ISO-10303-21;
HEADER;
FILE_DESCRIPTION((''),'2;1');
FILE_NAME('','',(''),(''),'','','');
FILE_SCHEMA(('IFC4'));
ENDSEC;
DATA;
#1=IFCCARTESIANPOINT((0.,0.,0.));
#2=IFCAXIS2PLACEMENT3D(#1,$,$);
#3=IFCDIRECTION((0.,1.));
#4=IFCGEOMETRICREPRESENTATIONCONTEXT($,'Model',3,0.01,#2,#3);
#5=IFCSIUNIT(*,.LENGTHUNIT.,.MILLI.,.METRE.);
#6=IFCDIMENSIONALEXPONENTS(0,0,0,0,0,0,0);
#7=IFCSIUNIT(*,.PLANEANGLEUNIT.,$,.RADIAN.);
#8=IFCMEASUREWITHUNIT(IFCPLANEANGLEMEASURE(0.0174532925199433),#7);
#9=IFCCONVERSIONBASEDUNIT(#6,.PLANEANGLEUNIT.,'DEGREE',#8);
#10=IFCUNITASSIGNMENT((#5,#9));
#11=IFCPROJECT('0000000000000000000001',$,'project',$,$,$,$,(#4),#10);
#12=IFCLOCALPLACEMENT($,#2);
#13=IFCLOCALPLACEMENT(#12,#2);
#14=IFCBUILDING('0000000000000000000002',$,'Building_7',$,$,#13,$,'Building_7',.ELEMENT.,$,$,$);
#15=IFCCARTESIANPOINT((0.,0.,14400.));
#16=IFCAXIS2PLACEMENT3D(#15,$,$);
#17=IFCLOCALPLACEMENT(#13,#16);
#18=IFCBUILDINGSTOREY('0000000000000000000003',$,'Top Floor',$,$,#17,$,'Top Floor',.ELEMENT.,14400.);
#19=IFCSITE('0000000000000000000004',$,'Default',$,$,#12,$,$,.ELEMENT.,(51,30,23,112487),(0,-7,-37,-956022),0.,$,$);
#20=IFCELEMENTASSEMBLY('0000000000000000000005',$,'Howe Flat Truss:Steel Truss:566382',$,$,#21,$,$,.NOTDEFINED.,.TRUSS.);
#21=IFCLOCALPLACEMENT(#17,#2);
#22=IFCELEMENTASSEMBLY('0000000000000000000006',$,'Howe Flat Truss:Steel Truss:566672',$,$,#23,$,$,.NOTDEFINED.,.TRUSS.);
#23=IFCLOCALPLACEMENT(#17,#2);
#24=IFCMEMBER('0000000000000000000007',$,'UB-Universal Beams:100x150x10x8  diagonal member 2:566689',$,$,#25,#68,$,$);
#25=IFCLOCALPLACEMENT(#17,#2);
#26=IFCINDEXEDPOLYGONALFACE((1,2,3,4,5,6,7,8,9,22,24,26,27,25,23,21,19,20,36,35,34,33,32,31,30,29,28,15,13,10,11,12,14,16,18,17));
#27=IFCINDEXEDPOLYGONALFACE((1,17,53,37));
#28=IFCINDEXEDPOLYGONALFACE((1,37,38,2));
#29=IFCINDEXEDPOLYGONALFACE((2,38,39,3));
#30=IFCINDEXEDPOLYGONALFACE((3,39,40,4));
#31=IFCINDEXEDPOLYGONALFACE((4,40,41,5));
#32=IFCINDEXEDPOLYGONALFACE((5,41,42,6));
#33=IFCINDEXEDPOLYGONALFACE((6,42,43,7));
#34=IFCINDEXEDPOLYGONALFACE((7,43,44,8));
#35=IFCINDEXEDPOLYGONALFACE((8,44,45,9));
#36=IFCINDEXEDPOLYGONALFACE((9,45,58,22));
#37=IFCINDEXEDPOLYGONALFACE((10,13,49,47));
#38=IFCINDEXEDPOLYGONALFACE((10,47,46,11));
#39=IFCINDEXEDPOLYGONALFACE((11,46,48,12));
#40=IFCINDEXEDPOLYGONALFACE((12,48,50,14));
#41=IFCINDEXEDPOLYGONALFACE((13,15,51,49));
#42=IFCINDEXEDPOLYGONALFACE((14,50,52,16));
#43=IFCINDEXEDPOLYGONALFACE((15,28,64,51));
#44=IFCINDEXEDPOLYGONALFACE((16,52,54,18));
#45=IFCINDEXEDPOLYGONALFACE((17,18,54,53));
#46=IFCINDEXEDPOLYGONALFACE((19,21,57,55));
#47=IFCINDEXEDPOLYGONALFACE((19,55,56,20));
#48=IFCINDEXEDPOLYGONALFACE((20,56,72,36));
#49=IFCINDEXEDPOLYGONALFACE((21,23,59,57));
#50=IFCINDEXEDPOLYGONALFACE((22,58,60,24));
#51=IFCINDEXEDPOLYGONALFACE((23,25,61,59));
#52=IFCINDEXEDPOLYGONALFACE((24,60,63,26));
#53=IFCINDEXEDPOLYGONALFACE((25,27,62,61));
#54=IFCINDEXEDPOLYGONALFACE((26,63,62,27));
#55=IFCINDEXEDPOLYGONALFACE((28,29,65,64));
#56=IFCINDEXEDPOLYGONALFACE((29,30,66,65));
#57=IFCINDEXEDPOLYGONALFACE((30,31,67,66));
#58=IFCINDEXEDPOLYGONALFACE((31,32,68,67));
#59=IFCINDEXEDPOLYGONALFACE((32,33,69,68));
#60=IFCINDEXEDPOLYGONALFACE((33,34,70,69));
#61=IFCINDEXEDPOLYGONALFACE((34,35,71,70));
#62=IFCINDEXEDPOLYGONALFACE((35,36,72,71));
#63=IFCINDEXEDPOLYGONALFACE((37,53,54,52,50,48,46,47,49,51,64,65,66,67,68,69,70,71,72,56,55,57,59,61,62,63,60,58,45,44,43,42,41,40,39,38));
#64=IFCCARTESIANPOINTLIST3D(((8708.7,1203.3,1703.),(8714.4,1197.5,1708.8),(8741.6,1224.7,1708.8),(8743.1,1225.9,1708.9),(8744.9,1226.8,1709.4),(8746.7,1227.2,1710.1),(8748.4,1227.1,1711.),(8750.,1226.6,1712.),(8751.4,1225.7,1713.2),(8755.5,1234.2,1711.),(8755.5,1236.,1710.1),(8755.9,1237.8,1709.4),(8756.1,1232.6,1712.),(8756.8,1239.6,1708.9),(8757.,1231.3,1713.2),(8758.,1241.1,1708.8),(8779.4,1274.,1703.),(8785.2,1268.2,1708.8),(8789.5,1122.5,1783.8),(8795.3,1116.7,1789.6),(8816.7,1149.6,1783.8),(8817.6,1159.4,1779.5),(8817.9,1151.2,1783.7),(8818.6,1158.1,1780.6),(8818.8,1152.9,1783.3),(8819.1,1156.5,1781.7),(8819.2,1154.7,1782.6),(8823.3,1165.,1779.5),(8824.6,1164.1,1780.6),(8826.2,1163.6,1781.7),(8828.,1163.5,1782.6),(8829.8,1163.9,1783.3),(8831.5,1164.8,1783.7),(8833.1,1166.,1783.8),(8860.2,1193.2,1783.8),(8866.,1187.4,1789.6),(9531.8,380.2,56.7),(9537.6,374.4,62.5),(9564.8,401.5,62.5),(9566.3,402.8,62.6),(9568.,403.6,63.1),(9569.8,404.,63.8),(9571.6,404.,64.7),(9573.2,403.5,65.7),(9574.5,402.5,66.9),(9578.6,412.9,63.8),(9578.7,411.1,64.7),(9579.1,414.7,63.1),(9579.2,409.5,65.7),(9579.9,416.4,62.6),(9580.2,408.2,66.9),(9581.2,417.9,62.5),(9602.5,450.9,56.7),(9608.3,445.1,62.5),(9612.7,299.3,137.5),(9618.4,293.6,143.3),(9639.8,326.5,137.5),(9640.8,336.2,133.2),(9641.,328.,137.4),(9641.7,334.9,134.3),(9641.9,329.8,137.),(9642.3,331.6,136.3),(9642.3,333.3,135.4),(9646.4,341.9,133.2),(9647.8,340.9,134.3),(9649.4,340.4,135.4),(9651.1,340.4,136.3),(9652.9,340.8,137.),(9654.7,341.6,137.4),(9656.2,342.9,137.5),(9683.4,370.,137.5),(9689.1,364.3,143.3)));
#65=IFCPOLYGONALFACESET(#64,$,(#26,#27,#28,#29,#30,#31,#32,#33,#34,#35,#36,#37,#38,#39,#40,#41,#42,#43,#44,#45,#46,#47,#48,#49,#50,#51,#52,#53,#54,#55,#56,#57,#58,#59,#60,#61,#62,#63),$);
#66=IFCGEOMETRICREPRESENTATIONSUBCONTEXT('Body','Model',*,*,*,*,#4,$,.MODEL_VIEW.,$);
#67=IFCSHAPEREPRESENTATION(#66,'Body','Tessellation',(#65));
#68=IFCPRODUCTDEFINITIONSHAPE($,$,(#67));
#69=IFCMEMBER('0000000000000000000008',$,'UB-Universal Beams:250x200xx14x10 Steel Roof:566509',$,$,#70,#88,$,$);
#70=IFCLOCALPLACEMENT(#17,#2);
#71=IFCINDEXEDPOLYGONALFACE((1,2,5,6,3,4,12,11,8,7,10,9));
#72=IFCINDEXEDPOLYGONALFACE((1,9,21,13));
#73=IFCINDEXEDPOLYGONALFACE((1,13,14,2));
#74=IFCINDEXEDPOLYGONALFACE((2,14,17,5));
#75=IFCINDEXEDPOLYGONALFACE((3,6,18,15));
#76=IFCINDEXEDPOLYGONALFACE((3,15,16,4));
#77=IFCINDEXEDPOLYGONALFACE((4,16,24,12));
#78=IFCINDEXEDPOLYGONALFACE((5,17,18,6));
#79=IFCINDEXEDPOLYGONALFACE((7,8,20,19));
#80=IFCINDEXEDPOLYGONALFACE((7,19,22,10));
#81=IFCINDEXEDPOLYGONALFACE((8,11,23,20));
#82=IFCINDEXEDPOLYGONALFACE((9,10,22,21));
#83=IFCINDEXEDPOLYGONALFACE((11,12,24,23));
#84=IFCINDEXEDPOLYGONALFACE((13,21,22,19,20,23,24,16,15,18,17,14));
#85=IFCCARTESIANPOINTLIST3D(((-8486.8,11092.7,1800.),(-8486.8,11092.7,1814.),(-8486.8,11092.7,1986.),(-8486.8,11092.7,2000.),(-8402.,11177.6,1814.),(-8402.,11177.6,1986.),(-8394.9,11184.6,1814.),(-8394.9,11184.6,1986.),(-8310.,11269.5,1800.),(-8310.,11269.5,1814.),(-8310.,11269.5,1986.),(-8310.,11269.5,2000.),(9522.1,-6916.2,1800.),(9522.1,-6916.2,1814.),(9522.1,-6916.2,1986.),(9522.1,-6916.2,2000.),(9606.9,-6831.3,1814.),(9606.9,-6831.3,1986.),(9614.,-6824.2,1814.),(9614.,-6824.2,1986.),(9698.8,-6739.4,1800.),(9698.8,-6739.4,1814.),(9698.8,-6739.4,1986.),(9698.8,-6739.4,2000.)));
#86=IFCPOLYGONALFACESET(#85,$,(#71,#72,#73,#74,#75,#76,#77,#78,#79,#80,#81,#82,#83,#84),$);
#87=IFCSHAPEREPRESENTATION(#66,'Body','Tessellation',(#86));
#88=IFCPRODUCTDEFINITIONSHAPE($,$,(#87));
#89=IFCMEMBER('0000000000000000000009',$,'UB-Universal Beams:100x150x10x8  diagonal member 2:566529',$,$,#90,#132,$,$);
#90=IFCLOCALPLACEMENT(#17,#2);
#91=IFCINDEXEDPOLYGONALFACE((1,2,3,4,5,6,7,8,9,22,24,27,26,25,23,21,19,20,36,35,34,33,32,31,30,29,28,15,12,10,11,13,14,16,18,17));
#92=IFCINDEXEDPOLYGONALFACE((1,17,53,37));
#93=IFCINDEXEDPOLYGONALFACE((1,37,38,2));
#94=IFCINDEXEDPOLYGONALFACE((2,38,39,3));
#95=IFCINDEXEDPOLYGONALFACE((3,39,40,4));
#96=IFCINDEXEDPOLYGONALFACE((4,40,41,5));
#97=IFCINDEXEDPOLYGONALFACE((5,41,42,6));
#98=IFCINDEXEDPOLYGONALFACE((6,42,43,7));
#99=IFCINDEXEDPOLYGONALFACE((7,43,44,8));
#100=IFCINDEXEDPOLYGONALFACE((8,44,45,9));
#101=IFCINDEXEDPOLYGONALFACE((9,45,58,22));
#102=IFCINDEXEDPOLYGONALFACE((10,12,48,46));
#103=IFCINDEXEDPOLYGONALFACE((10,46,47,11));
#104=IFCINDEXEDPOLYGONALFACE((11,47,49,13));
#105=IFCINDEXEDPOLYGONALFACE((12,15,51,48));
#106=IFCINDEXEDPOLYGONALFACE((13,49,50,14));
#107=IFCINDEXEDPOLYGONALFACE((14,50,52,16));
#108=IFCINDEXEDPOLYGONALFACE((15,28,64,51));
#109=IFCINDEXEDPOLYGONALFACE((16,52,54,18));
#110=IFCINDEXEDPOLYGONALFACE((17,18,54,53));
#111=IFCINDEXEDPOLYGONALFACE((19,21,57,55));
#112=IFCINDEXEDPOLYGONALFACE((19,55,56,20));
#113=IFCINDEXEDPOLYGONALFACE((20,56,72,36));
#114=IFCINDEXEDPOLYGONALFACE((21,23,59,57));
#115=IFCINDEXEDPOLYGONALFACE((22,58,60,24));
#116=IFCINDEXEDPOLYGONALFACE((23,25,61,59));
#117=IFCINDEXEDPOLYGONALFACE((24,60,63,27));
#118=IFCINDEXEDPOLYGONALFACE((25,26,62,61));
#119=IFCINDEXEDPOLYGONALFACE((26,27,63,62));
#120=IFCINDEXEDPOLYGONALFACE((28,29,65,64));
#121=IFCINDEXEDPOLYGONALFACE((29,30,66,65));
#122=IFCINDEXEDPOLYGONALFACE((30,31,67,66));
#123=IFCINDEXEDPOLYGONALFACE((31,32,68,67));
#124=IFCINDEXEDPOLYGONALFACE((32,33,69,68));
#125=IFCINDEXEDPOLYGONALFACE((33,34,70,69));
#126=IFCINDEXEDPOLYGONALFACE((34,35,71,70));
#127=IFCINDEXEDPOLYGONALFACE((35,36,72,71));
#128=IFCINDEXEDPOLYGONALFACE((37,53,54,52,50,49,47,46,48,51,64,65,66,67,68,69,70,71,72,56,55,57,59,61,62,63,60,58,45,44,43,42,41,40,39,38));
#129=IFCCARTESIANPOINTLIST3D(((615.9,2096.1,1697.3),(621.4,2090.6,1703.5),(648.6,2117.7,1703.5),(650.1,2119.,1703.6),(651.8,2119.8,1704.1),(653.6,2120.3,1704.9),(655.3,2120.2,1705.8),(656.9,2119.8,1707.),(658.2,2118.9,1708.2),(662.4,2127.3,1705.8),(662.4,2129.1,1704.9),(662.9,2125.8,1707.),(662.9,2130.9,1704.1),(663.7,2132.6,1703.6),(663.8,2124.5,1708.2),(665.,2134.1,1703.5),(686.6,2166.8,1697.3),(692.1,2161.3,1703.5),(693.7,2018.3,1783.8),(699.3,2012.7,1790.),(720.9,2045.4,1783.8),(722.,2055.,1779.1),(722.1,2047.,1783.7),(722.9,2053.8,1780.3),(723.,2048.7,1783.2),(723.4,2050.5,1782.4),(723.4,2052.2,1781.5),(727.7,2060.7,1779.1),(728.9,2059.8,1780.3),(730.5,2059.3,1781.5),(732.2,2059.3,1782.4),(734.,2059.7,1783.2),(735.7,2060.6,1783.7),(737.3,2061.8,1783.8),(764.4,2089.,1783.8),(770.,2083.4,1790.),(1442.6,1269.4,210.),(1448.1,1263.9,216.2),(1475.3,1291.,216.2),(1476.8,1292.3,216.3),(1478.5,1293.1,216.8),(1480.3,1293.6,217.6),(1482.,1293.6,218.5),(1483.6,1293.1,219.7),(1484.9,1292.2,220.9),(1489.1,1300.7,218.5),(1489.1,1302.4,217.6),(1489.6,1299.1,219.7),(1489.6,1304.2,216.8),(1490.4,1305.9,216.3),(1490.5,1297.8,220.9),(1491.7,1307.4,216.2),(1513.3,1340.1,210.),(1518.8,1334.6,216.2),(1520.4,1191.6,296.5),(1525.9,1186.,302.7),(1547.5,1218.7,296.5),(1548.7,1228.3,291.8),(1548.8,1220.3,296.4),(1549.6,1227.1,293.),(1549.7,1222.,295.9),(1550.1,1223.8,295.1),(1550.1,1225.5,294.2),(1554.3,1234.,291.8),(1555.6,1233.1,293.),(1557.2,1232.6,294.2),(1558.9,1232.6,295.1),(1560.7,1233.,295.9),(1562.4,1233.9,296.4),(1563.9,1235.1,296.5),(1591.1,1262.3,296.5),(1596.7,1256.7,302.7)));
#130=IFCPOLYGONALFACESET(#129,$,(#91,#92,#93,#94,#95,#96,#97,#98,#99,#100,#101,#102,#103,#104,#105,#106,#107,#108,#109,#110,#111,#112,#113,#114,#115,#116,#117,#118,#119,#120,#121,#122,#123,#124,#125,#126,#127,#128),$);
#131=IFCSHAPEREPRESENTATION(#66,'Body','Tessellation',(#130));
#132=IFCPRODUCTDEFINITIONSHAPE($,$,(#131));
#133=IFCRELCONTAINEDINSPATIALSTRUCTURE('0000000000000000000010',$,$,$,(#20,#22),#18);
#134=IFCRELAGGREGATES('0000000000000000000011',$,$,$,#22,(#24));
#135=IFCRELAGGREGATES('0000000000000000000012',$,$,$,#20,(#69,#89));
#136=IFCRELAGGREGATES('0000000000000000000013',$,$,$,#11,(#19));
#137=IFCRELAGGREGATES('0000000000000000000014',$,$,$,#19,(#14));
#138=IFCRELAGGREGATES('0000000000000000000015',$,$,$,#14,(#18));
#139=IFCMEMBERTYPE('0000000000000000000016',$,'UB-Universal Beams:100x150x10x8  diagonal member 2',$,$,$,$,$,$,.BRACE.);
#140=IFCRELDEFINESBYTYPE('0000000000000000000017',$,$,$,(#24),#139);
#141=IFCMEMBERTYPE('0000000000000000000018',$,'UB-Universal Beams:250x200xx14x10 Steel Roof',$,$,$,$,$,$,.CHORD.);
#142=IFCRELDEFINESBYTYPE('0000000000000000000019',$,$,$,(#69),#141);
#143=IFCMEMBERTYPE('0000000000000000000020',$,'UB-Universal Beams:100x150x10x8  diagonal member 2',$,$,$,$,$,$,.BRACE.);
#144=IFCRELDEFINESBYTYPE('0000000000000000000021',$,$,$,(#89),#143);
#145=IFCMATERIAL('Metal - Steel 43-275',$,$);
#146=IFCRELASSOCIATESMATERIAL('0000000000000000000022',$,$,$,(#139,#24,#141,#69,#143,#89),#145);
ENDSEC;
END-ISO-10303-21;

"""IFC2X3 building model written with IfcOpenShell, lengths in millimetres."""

from ifc_helpers import new_model, entity, si_unit, converted_unit, direction, frame, frame_2d, origin, place, context, subcontext, project, spatial, polyline, circle_curve, parameter, trimmed, segment, composite_curve, outline, extrude, source, transform, mapped, material, type_object, type_shapes, element, aggregate, save


model = new_model("IFC2X3")

# Units and contexts
model_context = context("Model", 3, precision=0.01, world=origin(), true_north=direction((0.0, 1.0)))
body_context = subcontext(model_context, "Body", "Model", "MODEL_VIEW")
ifc_project = project(units=[si_unit("LENGTHUNIT", "METRE", prefix="MILLI"), converted_unit("PLANEANGLEUNIT", "DEGREE", entity("IfcPlaneAngleMeasure", 0.0174532925199433), si_unit("PLANEANGLEUNIT", "RADIAN"), dimensions=[0, 0, 0, 0, 0, 0, 0])], contexts=[model_context])

# Site, building, storey
site_placement = place(None, origin())
site = spatial("IfcSite", under=ifc_project, at=site_placement, Name="Default", CompositionType="ELEMENT", RefLatitude=(51, 30, 23, 112487), RefLongitude=(0, -7, -37, -956022), RefElevation=0.0)
building_placement = place(site_placement, origin())
building = spatial("IfcBuilding", under=site, at=building_placement, Name="Building_7", LongName="Building_7", CompositionType="ELEMENT")
storey_placement = place(building_placement, frame((0.0, 0.0, 14400.0)))
storey = spatial("IfcBuildingStorey", under=building, at=storey_placement, Name="Top Floor", LongName="Top Floor", CompositionType="ELEMENT", Elevation=14400.0)

# Shared definitions
ifc_material = material(Name="Metal - Steel 43-275")

# Element assemblies
assembly_1_placement = place(storey_placement, origin())
assembly_1 = element("IfcElementAssembly", 1, at=assembly_1_placement, inside=storey, Name="Howe Flat Truss:Steel Truss:566382", AssemblyPlace="NOTDEFINED", PredefinedType="TRUSS")
assembly_2_placement = place(storey_placement, origin())
assembly_2 = element("IfcElementAssembly", 2, at=assembly_2_placement, inside=storey, Name="Howe Flat Truss:Steel Truss:566672", AssemblyPlace="NOTDEFINED", PredefinedType="TRUSS")

# Members
member_type_1 = type_object("IfcMemberType", Name="UB-Universal Beams:100x150x10x8  diagonal member 2", PredefinedType="BRACE", material=ifc_material)
shared_shape_1 = source(origin(), body_context, "Body", "SweptSolid", [
    extrude(outline(composite_curve([segment(polyline([(-50.0, -65.0), (-50.0, -75.0)]), True, "CONTINUOUS"), segment(polyline([(-50.0, -75.0), (50.0, -75.0)]), True, "CONTINUOUS"), segment(polyline([(50.0, -75.0), (50.0, -65.0)]), True, "CONTINUOUS"), segment(polyline([(50.0, -65.0), (11.6, -65.0)]), True, "CONTINUOUS"), segment(trimmed(circle_curve(frame_2d((11.6, -57.4), x_axis=(1.0, 0.0)), 7.6), [parameter(180.0)], [parameter(270.0)], True, "PARAMETER"), False, "CONTINUOUS"), segment(polyline([(4.0, -57.4), (4.0, 57.4)]), True, "CONTINUOUS"), segment(trimmed(circle_curve(frame_2d((11.6, 57.4), x_axis=(1.0, 0.0)), 7.6), [parameter(90.0)], [parameter(180.0)], True, "PARAMETER"), False, "CONTINUOUS"), segment(polyline([(11.6, 65.0), (50.0, 65.0)]), True, "CONTINUOUS"), segment(polyline([(50.0, 65.0), (50.0, 75.0)]), True, "CONTINUOUS"), segment(polyline([(50.0, 75.0), (-50.0, 75.0)]), True, "CONTINUOUS"), segment(polyline([(-50.0, 75.0), (-50.0, 65.0)]), True, "CONTINUOUS"), segment(polyline([(-50.0, 65.0), (-11.6, 65.0)]), True, "CONTINUOUS"), segment(trimmed(circle_curve(frame_2d((-11.6, 57.4), x_axis=(1.0, 0.0)), 7.6), [parameter(360.0)], [parameter(90.0)], True, "PARAMETER"), False, "CONTINUOUS"), segment(polyline([(-4.0, 57.4), (-4.0, -57.4)]), True, "CONTINUOUS"), segment(trimmed(circle_curve(frame_2d((-11.6, -57.4), x_axis=(1.0, 0.0)), 7.6), [parameter(270.0)], [parameter(360.0)], True, "PARAMETER"), False, "CONTINUOUS"), segment(polyline([(-11.6, -65.0), (-50.0, -65.0)]), True, "CONTINUOUS")], self_intersect=False)), frame((-1102.2, 0.0, 0.0), z_axis=(-1.0, 0.0, 0.0), x_axis=(0.0, -1.0, 0.0)), (0.0, 0.0, -1.0), 2016.3),
])
type_shapes(member_type_1, [shared_shape_1])
member_1_placement = place(assembly_2_placement, frame((9160.5, 822.2, 1000.0), z_axis=(-0.57735, 0.57735, -0.57735), x_axis=(-0.408248, 0.408248, 0.816497)))
member_1 = element("IfcMember", 3, at=member_1_placement, type_object=member_type_1, material=ifc_material, Name="UB-Universal Beams:100x150x10x8  diagonal member 2:566689", context=body_context, shape_type="MappedRepresentation", body=[
    mapped(shared_shape_1, transform((0.0, 0.0, 0.0), scale=1.0)),
])
aggregate(assembly_2, [member_1])
member_type_2 = type_object("IfcMemberType", Name="UB-Universal Beams:250x200xx14x10 Steel Roof", PredefinedType="CHORD", material=ifc_material)
shared_shape_2 = source(origin(), body_context, "Body", "SweptSolid", [
    extrude(outline(polyline([(-125.0, -86.0), (-125.0, -100.0), (125.0, -100.0), (125.0, -86.0), (5.0, -86.0), (5.0, 86.0), (125.0, 86.0), (125.0, 100.0), (-125.0, 100.0), (-125.0, 86.0), (-5.0, 86.0), (-5.0, -86.0), (-125.0, -86.0)])), frame((-12734.2, 0.0, 0.0), z_axis=(-1.0, 0.0, 0.0), x_axis=(0.0, -1.0, 0.0)), (0.0, 0.0, -1.0), 25468.4),
])
type_shapes(member_type_2, [shared_shape_2])
member_2_placement = place(assembly_1_placement, frame((606.0, 2176.7, 1900.0), z_axis=(0.0, 0.0, 1.0), x_axis=(-0.707107, 0.707107, 0.0)))
member_2 = element("IfcMember", 4, at=member_2_placement, type_object=member_type_2, material=ifc_material, Name="UB-Universal Beams:250x200xx14x10 Steel Roof:566509", context=body_context, shape_type="MappedRepresentation", body=[
    mapped(shared_shape_2, transform((0.0, 0.0, 0.0), scale=1.0)),
])
member_type_3 = type_object("IfcMemberType", Name="UB-Universal Beams:100x150x10x8  diagonal member 2", PredefinedType="BRACE", material=ifc_material)
shared_shape_3 = source(origin(), body_context, "Body", "SweptSolid", [
    extrude(outline(composite_curve([segment(polyline([(-50.0, -65.0), (-50.0, -75.0)]), True, "CONTINUOUS"), segment(polyline([(-50.0, -75.0), (50.0, -75.0)]), True, "CONTINUOUS"), segment(polyline([(50.0, -75.0), (50.0, -65.0)]), True, "CONTINUOUS"), segment(polyline([(50.0, -65.0), (11.6, -65.0)]), True, "CONTINUOUS"), segment(trimmed(circle_curve(frame_2d((11.6, -57.4), x_axis=(1.0, 0.0)), 7.6), [parameter(180.0)], [parameter(270.0)], True, "PARAMETER"), False, "CONTINUOUS"), segment(polyline([(4.0, -57.4), (4.0, 57.4)]), True, "CONTINUOUS"), segment(trimmed(circle_curve(frame_2d((11.6, 57.4), x_axis=(1.0, 0.0)), 7.6), [parameter(90.0)], [parameter(180.0)], True, "PARAMETER"), False, "CONTINUOUS"), segment(polyline([(11.6, 65.0), (50.0, 65.0)]), True, "CONTINUOUS"), segment(polyline([(50.0, 65.0), (50.0, 75.0)]), True, "CONTINUOUS"), segment(polyline([(50.0, 75.0), (-50.0, 75.0)]), True, "CONTINUOUS"), segment(polyline([(-50.0, 75.0), (-50.0, 65.0)]), True, "CONTINUOUS"), segment(polyline([(-50.0, 65.0), (-11.6, 65.0)]), True, "CONTINUOUS"), segment(trimmed(circle_curve(frame_2d((-11.6, 57.4), x_axis=(1.0, 0.0)), 7.6), [parameter(360.0)], [parameter(90.0)], True, "PARAMETER"), False, "CONTINUOUS"), segment(polyline([(-4.0, 57.4), (-4.0, -57.4)]), True, "CONTINUOUS"), segment(trimmed(circle_curve(frame_2d((-11.6, -57.4), x_axis=(1.0, 0.0)), 7.6), [parameter(270.0)], [parameter(360.0)], True, "PARAMETER"), False, "CONTINUOUS"), segment(polyline([(-11.6, -65.0), (-50.0, -65.0)]), True, "CONTINUOUS")], self_intersect=False)), frame((-945.9, 0.0, 0.0), z_axis=(-1.0, 0.0, 0.0), x_axis=(0.0, -1.0, 0.0)), (0.0, 0.0, -1.0), 1891.8),
])
type_shapes(member_type_3, [shared_shape_3])
member_3_placement = place(assembly_1_placement, frame((1106.3, 1676.4, 1000.0), z_axis=(-0.555916, 0.555916, -0.617992), x_axis=(-0.436986, 0.436986, 0.786184)))
member_3 = element("IfcMember", 5, at=member_3_placement, type_object=member_type_3, material=ifc_material, Name="UB-Universal Beams:100x150x10x8  diagonal member 2:566529", context=body_context, shape_type="MappedRepresentation", body=[
    mapped(shared_shape_3, transform((0.0, 0.0, 0.0), scale=1.0)),
])
aggregate(assembly_1, [member_2, member_3])

save(model, "model.ifc")
